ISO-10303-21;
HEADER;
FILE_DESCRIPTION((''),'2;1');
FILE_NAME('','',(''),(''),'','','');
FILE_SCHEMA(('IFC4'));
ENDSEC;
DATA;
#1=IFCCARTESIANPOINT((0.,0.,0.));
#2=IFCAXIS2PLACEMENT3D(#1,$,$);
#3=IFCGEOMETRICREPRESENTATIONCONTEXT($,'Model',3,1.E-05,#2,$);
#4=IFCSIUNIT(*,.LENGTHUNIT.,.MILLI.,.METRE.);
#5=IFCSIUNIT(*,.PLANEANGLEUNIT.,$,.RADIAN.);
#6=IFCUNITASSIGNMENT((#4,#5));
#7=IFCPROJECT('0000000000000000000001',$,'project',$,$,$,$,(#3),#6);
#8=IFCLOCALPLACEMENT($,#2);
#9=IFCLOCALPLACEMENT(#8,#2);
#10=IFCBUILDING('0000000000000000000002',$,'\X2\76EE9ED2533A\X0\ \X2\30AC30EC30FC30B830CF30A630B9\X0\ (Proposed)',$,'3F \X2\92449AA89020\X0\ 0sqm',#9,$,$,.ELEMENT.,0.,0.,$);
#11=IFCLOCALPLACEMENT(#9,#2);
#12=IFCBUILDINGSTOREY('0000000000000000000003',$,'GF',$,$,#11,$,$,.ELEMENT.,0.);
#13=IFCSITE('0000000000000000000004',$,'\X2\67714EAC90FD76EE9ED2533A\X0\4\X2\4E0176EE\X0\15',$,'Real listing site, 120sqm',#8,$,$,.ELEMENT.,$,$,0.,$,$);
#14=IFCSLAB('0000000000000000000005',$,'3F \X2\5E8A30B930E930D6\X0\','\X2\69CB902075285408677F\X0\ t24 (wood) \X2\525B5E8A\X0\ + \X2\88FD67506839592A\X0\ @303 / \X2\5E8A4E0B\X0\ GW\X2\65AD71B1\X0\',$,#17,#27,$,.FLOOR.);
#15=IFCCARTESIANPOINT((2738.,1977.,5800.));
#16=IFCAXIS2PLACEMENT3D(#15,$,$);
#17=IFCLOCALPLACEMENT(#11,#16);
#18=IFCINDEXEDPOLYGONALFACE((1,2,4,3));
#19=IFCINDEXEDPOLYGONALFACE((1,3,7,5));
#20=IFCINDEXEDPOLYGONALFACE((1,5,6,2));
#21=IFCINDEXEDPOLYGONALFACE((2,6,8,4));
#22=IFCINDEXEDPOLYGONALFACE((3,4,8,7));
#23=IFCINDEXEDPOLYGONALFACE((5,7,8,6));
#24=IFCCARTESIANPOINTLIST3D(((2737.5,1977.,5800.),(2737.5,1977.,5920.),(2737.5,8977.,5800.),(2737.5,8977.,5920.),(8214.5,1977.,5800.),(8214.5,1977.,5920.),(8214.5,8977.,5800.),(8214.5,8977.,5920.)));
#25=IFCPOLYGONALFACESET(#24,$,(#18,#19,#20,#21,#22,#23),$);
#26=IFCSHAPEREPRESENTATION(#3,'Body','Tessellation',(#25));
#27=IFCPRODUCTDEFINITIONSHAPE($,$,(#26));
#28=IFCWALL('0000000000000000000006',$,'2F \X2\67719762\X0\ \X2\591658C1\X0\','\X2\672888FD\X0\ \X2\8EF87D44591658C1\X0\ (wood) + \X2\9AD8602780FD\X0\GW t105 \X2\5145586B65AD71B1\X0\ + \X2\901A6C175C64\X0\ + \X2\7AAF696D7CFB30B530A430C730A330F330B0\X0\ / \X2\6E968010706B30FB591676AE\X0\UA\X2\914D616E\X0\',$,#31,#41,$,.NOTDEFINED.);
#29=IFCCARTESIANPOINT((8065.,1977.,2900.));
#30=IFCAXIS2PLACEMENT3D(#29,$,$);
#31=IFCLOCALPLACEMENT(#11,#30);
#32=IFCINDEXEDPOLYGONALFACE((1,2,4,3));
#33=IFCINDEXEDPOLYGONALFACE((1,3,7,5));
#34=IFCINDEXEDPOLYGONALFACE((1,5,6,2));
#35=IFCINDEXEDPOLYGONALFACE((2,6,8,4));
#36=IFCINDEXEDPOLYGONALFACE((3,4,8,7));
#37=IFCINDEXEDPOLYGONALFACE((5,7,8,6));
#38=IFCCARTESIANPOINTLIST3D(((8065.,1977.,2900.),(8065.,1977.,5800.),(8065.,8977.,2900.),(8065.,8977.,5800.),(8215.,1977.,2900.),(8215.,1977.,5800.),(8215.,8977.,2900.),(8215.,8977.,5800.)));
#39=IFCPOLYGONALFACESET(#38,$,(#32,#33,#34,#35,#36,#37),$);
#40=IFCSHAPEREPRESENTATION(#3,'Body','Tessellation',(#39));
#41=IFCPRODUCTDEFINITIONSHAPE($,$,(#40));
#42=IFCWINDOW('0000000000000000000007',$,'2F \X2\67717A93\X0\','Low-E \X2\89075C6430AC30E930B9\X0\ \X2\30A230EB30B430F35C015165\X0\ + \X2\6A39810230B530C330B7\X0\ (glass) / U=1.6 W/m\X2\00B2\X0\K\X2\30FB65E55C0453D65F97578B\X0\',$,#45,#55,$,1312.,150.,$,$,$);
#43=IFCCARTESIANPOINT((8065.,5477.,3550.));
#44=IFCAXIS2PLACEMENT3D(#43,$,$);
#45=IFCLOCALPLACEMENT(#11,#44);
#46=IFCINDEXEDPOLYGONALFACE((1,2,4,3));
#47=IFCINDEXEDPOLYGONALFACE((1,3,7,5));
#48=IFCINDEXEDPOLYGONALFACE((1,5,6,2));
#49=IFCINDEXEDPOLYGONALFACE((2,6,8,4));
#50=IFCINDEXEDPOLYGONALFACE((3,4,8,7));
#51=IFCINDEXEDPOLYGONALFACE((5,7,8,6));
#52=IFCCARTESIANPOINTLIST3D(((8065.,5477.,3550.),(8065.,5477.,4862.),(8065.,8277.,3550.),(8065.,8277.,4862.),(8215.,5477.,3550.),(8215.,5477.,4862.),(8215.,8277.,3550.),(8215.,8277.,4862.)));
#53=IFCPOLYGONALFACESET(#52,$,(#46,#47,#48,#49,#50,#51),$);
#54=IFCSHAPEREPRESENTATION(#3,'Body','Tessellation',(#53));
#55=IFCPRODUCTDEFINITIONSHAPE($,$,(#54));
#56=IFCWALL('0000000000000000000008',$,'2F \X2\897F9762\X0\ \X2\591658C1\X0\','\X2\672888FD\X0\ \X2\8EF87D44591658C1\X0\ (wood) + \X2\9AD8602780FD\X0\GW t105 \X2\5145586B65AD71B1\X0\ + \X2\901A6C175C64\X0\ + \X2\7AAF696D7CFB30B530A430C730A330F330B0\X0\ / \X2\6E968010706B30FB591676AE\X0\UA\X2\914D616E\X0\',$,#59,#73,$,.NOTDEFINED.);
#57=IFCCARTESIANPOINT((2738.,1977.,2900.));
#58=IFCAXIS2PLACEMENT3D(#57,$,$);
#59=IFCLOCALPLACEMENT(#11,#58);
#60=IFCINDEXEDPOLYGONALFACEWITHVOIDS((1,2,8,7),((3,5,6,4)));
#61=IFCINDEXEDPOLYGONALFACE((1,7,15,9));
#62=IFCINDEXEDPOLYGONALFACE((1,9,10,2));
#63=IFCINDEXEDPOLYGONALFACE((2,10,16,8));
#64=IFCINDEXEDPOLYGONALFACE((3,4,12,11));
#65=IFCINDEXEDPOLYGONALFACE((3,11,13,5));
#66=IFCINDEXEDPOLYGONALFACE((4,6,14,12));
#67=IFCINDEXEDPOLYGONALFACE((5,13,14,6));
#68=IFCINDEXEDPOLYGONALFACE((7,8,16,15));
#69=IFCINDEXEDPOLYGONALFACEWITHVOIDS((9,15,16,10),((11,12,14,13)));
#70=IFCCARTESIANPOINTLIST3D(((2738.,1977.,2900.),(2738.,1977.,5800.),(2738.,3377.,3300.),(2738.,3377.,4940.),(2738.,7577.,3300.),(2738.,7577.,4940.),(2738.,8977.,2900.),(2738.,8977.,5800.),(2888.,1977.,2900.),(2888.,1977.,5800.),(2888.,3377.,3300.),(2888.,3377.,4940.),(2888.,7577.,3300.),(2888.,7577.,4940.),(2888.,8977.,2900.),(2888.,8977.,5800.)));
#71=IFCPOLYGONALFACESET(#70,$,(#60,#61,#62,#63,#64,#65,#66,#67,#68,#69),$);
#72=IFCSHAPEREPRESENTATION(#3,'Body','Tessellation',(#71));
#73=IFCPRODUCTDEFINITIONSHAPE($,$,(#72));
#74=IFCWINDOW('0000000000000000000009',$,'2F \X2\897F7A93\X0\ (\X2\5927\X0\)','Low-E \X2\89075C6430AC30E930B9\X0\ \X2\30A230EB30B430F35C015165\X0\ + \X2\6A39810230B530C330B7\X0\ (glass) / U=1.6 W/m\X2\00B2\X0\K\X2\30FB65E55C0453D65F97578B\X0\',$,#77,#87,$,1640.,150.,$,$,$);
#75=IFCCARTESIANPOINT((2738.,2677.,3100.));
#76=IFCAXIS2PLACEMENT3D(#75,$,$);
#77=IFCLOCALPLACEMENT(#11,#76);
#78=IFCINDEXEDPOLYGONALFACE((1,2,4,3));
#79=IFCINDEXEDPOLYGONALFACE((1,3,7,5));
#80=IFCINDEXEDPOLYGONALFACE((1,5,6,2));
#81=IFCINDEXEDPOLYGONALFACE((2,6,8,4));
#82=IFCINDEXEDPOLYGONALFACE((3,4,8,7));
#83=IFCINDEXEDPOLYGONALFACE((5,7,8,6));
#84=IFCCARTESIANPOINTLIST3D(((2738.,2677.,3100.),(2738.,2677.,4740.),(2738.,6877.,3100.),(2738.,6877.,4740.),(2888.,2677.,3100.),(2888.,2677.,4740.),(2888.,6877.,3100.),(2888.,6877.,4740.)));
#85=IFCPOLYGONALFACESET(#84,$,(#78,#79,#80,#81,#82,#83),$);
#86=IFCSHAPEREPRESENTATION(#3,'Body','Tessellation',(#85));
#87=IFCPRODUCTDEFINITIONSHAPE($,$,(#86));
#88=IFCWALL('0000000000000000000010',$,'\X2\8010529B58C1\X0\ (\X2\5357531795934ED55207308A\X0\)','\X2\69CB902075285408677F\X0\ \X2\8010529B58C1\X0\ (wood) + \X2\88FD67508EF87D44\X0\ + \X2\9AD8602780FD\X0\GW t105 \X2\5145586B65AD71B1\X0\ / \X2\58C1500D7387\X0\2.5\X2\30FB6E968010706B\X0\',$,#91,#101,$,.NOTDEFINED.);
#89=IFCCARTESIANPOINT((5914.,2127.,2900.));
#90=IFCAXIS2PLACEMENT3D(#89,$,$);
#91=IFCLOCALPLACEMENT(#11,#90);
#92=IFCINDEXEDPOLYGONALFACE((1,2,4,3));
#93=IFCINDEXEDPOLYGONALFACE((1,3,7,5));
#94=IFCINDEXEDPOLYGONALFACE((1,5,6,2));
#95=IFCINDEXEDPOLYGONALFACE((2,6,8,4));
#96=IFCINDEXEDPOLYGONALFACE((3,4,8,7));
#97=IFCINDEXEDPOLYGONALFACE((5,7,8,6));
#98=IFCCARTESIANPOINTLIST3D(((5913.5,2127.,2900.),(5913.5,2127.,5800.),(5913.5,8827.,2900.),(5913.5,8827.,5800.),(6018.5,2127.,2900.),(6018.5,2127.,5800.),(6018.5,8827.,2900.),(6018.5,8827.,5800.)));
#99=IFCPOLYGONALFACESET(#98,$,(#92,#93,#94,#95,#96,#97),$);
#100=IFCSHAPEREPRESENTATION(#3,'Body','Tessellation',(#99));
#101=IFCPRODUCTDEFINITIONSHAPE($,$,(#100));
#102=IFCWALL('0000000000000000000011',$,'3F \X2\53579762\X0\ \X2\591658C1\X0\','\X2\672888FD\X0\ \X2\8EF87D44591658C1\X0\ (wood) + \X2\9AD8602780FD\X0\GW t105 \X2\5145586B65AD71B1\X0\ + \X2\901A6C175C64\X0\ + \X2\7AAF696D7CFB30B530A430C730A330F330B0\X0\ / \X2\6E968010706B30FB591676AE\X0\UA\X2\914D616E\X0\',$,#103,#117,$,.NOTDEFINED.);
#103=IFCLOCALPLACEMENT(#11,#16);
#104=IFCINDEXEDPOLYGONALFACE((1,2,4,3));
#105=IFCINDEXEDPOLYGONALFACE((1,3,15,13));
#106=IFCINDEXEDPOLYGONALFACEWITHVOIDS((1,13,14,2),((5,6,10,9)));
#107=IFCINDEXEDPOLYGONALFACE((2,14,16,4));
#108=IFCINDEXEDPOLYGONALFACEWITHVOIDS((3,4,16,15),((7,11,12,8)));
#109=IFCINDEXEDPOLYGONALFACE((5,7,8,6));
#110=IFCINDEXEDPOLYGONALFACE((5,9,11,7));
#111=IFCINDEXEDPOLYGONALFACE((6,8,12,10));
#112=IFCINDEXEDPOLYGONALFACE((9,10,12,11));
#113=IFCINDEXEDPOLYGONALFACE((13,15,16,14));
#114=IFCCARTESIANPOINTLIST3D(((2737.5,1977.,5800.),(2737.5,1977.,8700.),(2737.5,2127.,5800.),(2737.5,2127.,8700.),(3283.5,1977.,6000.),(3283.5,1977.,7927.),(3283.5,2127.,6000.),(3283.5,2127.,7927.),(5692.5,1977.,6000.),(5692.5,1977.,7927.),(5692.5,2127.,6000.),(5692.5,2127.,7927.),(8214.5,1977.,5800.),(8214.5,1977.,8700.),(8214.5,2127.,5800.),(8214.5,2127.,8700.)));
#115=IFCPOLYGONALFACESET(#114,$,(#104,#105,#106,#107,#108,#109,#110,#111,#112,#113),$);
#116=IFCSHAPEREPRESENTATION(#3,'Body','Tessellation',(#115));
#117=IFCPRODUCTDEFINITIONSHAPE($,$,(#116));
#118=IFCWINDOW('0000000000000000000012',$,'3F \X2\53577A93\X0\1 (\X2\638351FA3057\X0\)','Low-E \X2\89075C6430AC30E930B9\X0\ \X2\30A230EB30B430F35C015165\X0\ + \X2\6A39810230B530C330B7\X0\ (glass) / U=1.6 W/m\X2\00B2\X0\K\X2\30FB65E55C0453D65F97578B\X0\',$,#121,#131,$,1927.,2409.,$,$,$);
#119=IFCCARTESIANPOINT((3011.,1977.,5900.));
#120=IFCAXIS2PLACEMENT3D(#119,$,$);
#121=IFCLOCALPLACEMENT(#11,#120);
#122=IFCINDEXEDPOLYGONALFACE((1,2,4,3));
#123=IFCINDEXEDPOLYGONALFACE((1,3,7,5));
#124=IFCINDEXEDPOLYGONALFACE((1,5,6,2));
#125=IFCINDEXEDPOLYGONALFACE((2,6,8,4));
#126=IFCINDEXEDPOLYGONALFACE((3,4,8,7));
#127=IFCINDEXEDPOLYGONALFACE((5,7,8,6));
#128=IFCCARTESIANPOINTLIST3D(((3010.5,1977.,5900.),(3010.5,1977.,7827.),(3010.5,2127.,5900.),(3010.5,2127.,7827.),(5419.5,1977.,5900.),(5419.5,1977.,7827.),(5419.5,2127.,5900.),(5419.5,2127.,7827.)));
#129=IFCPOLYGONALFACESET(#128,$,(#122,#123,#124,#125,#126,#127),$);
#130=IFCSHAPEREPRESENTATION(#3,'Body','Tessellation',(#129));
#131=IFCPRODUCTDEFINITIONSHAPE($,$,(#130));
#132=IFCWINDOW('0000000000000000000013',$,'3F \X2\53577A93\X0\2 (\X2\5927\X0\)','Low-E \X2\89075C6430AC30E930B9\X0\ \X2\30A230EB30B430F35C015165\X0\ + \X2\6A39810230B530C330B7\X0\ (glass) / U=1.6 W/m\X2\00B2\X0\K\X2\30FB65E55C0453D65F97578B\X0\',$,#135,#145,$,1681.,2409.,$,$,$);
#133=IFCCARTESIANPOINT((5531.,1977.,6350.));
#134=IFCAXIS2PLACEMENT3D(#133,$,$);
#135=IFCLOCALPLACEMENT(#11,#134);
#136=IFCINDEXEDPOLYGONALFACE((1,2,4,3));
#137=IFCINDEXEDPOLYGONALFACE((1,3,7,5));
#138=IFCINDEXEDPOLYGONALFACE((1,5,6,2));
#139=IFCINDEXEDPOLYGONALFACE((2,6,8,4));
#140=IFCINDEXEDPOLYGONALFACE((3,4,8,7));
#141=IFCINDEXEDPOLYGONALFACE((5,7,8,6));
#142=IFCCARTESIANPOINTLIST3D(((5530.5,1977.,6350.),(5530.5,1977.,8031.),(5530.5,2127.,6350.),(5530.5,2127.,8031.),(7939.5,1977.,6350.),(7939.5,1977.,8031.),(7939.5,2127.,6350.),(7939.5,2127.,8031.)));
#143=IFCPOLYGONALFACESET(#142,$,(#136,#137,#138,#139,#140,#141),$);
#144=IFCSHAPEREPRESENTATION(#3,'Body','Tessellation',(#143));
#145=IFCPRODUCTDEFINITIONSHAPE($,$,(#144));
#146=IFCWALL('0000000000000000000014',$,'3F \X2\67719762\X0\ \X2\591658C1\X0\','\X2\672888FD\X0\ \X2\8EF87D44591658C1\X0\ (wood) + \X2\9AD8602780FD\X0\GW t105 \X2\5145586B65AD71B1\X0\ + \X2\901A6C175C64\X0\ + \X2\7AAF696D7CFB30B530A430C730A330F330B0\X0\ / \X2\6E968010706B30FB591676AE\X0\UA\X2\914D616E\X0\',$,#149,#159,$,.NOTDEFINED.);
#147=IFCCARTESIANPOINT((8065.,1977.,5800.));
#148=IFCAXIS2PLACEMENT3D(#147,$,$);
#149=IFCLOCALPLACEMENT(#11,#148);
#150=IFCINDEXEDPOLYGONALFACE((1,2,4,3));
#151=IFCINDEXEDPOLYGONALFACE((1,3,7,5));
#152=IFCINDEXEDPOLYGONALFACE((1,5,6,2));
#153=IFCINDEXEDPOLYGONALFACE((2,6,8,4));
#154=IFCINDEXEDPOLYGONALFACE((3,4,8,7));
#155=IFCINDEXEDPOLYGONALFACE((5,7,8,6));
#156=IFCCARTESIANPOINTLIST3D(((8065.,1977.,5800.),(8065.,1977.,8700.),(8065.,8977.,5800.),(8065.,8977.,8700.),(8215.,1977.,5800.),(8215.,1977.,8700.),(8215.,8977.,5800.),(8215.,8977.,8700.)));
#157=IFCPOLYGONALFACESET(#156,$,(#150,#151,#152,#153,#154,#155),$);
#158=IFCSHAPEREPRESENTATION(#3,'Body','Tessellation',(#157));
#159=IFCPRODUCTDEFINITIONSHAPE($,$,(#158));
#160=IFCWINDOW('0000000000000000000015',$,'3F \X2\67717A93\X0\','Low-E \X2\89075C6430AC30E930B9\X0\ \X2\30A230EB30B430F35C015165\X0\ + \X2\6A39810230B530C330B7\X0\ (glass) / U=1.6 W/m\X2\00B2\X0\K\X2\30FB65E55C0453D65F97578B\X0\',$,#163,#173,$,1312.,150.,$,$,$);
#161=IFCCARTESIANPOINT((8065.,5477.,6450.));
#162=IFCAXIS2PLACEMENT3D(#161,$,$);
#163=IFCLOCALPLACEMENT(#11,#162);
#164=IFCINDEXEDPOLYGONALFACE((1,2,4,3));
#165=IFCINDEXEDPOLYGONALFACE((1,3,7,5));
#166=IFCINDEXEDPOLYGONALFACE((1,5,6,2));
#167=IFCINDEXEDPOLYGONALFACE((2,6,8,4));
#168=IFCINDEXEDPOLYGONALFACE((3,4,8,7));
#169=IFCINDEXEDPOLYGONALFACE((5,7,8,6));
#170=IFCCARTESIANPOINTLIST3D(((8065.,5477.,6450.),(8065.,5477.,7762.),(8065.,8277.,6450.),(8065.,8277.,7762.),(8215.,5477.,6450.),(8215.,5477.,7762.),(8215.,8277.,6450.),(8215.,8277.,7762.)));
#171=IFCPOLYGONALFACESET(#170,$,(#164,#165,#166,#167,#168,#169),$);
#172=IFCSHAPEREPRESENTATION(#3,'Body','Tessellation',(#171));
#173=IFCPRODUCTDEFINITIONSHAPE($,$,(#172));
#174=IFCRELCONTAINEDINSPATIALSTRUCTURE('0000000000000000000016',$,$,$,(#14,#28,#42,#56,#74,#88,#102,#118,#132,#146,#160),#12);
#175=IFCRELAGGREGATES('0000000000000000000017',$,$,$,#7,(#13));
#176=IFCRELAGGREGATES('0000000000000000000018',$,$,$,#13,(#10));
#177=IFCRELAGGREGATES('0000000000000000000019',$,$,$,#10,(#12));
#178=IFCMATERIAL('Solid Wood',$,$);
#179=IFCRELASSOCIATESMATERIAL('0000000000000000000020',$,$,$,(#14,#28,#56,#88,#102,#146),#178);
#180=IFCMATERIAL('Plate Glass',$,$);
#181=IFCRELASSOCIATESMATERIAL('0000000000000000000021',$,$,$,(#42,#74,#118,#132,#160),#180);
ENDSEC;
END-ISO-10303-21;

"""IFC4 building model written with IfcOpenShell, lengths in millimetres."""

from ifc_helpers import new_model, si_unit, frame, frame_2d, origin, place, context, project, spatial, rectangle, extrude, material, element, fill, save


model = new_model("IFC4")

# Units and contexts
model_context = context("Model", 3, precision=1e-05, world=origin())
ifc_project = project(units=[si_unit("LENGTHUNIT", "METRE", prefix="MILLI"), si_unit("PLANEANGLEUNIT", "RADIAN")], contexts=[model_context])

# Site, building, storey
site_placement = place(None, origin())
site = spatial("IfcSite", under=ifc_project, at=site_placement, Name="東京都目黒区4丁目15", ObjectType="Real listing site, 120sqm", CompositionType="ELEMENT", RefElevation=0.0)
building_placement = place(site_placement, origin())
building = spatial("IfcBuilding", under=site, at=building_placement, Name="目黒区 ガレージハウス (Proposed)", ObjectType="3F 鉄骨造 0sqm", CompositionType="ELEMENT", ElevationOfRefHeight=0.0, ElevationOfTerrain=0.0)
storey_placement = place(building_placement, origin())
storey = spatial("IfcBuildingStorey", under=building, at=storey_placement, Name="GF", CompositionType="ELEMENT", Elevation=0.0)

# Slab
ifc_material_1 = material(Name="Solid Wood")
slab_placement = place(storey_placement, frame((2738.0, 1977.0, 5800.0)))
element("IfcSlab", 1, at=slab_placement, inside=storey, material=ifc_material_1, Name="3F 床スラブ", Description="構造用合板 t24 (wood) 剛床 + 製材根太 @303 / 床下 GW断熱", PredefinedType="FLOOR", context=model_context, shape_type="SweptSolid", body=[
    extrude(rectangle(XDim=5477.0, YDim=7000.0, at=frame_2d((2738.0, 3500.0))), frame((2738.0, 1977.0, 5800.0)), (0.0, 0.0, 1.0), 120.0),
])

# Walls, openings, windows
wall_1_placement = place(storey_placement, frame((8065.0, 1977.0, 2900.0)))
wall_1 = element("IfcWall", 2, at=wall_1_placement, inside=storey, material=ifc_material_1, Name="2F 東面 外壁", Description="木製 軸組外壁 (wood) + 高性能GW t105 充填断熱 + 通気層 + 窯業系サイディング / 準耐火・外皮UA配慮", PredefinedType="NOTDEFINED", context=model_context, shape_type="SweptSolid", body=[
    extrude(rectangle(XDim=150.0, YDim=7000.0, at=frame_2d((75.0, 3500.0))), frame((8065.0, 1977.0, 2900.0)), (0.0, 0.0, 1.0), 2900.0),
])
opening_1_placement = place(storey_placement, frame((8065.0, 5477.0, 3550.0)))
opening_1 = element("IfcOpeningElement", 3, at=opening_1_placement, cuts=wall_1, PredefinedType="NOTDEFINED", context=model_context, shape_type="SweptSolid", body=[
    extrude(rectangle(XDim=150.0, YDim=2800.0, at=frame_2d((75.0, 1400.0))), frame((8065.0, 5477.0, 3550.0)), (0.0, 0.0, 1.0), 1312.0),
])
ifc_material_2 = material(Name="Plate Glass")
window_1_placement = place(storey_placement, frame((8065.0, 5477.0, 3550.0)))
window_1 = element("IfcWindow", 4, at=window_1_placement, inside=storey, material=ifc_material_2, Name="2F 東窓", Description="Low-E 複層ガラス アルゴン封入 + 樹脂サッシ (glass) / U=1.6 W/m²K・日射取得型", OverallHeight=1312.0, OverallWidth=150.0, context=model_context, shape_type="SweptSolid", body=[
    extrude(rectangle(XDim=150.0, YDim=2800.0, at=frame_2d((75.0, 1400.0))), frame((8065.0, 5477.0, 3550.0)), (0.0, 0.0, 1.0), 1312.0),
])
fill(opening_1, window_1)
wall_2_placement = place(storey_placement, frame((2738.0, 1977.0, 2900.0)))
wall_2 = element("IfcWall", 5, at=wall_2_placement, inside=storey, material=ifc_material_1, Name="2F 西面 外壁", Description="木製 軸組外壁 (wood) + 高性能GW t105 充填断熱 + 通気層 + 窯業系サイディング / 準耐火・外皮UA配慮", PredefinedType="NOTDEFINED", context=model_context, shape_type="SweptSolid", body=[
    extrude(rectangle(XDim=150.0, YDim=7000.0, at=frame_2d((75.0, 3500.0))), frame((2738.0, 1977.0, 2900.0)), (0.0, 0.0, 1.0), 2900.0),
])
opening_2_placement = place(storey_placement, frame((2738.0, 2677.0, 3100.0)))
opening_2 = element("IfcOpeningElement", 6, at=opening_2_placement, cuts=wall_2, PredefinedType="NOTDEFINED", context=model_context, shape_type="SweptSolid", body=[
    extrude(rectangle(XDim=150.0, YDim=4200.0, at=frame_2d((75.0, 2100.0))), frame((2738.0, 2677.0, 3100.0)), (0.0, 0.0, 1.0), 1640.0),
])
window_2_placement = place(storey_placement, frame((2738.0, 2677.0, 3100.0)))
window_2 = element("IfcWindow", 7, at=window_2_placement, inside=storey, material=ifc_material_2, Name="2F 西窓 (大)", Description="Low-E 複層ガラス アルゴン封入 + 樹脂サッシ (glass) / U=1.6 W/m²K・日射取得型", OverallHeight=1640.0, OverallWidth=150.0, context=model_context, shape_type="SweptSolid", body=[
    extrude(rectangle(XDim=150.0, YDim=4200.0, at=frame_2d((75.0, 2100.0))), frame((2738.0, 2677.0, 3100.0)), (0.0, 0.0, 1.0), 1640.0),
])
fill(opening_2, window_2)

# Wall
wall_3_placement = place(storey_placement, frame((5914.0, 2127.0, 2900.0)))
element("IfcWall", 8, at=wall_3_placement, inside=storey, material=ifc_material_1, Name="耐力壁 (南北間仕切り)", Description="構造用合板 耐力壁 (wood) + 製材軸組 + 高性能GW t105 充填断熱 / 壁倍率2.5・準耐火", PredefinedType="NOTDEFINED", context=model_context, shape_type="SweptSolid", body=[
    extrude(rectangle(XDim=105.0, YDim=6700.0, at=frame_2d((52.0, 3350.0))), frame((5914.0, 2127.0, 2900.0)), (0.0, 0.0, 1.0), 2900.0),
])

# Wall, openings, windows
wall_4_placement = place(storey_placement, frame((2738.0, 1977.0, 5800.0)))
wall_4 = element("IfcWall", 9, at=wall_4_placement, inside=storey, material=ifc_material_1, Name="3F 南面 外壁", Description="木製 軸組外壁 (wood) + 高性能GW t105 充填断熱 + 通気層 + 窯業系サイディング / 準耐火・外皮UA配慮", PredefinedType="NOTDEFINED", context=model_context, shape_type="SweptSolid", body=[
    extrude(rectangle(XDim=5477.0, YDim=150.0, at=frame_2d((2738.0, 75.0))), frame((2738.0, 1977.0, 5800.0)), (0.0, 0.0, 1.0), 2900.0),
])
opening_3_placement = place(storey_placement, frame((3011.0, 1977.0, 5900.0)))
opening_3 = element("IfcOpeningElement", 10, at=opening_3_placement, cuts=wall_4, PredefinedType="NOTDEFINED", context=model_context, shape_type="SweptSolid", body=[
    extrude(rectangle(XDim=2409.0, YDim=150.0, at=frame_2d((1204.0, 75.0))), frame((3011.0, 1977.0, 5900.0)), (0.0, 0.0, 1.0), 1927.0),
])
opening_4_placement = place(storey_placement, frame((5531.0, 1977.0, 6350.0)))
opening_4 = element("IfcOpeningElement", 11, at=opening_4_placement, cuts=wall_4, PredefinedType="NOTDEFINED", context=model_context, shape_type="SweptSolid", body=[
    extrude(rectangle(XDim=2409.0, YDim=150.0, at=frame_2d((1204.0, 75.0))), frame((5531.0, 1977.0, 6350.0)), (0.0, 0.0, 1.0), 1681.0),
])
window_3_placement = place(storey_placement, frame((3011.0, 1977.0, 5900.0)))
window_3 = element("IfcWindow", 12, at=window_3_placement, inside=storey, material=ifc_material_2, Name="3F 南窓1 (掃出し)", Description="Low-E 複層ガラス アルゴン封入 + 樹脂サッシ (glass) / U=1.6 W/m²K・日射取得型", OverallHeight=1927.0, OverallWidth=2409.0, context=model_context, shape_type="SweptSolid", body=[
    extrude(rectangle(XDim=2409.0, YDim=150.0, at=frame_2d((1204.0, 75.0))), frame((3011.0, 1977.0, 5900.0)), (0.0, 0.0, 1.0), 1927.0),
])
fill(opening_3, window_3)
window_4_placement = place(storey_placement, frame((5531.0, 1977.0, 6350.0)))
window_4 = element("IfcWindow", 13, at=window_4_placement, inside=storey, material=ifc_material_2, Name="3F 南窓2 (大)", Description="Low-E 複層ガラス アルゴン封入 + 樹脂サッシ (glass) / U=1.6 W/m²K・日射取得型", OverallHeight=1681.0, OverallWidth=2409.0, context=model_context, shape_type="SweptSolid", body=[
    extrude(rectangle(XDim=2409.0, YDim=150.0, at=frame_2d((1204.0, 75.0))), frame((5531.0, 1977.0, 6350.0)), (0.0, 0.0, 1.0), 1681.0),
])
fill(opening_4, window_4)

# Wall, opening, window
wall_5_placement = place(storey_placement, frame((8065.0, 1977.0, 5800.0)))
wall_5 = element("IfcWall", 14, at=wall_5_placement, inside=storey, material=ifc_material_1, Name="3F 東面 外壁", Description="木製 軸組外壁 (wood) + 高性能GW t105 充填断熱 + 通気層 + 窯業系サイディング / 準耐火・外皮UA配慮", PredefinedType="NOTDEFINED", context=model_context, shape_type="SweptSolid", body=[
    extrude(rectangle(XDim=150.0, YDim=7000.0, at=frame_2d((75.0, 3500.0))), frame((8065.0, 1977.0, 5800.0)), (0.0, 0.0, 1.0), 2900.0),
])
opening_5_placement = place(storey_placement, frame((8065.0, 5477.0, 6450.0)))
opening_5 = element("IfcOpeningElement", 15, at=opening_5_placement, cuts=wall_5, PredefinedType="NOTDEFINED", context=model_context, shape_type="SweptSolid", body=[
    extrude(rectangle(XDim=150.0, YDim=2800.0, at=frame_2d((75.0, 1400.0))), frame((8065.0, 5477.0, 6450.0)), (0.0, 0.0, 1.0), 1312.0),
])
window_5_placement = place(storey_placement, frame((8065.0, 5477.0, 6450.0)))
window_5 = element("IfcWindow", 16, at=window_5_placement, inside=storey, material=ifc_material_2, Name="3F 東窓", Description="Low-E 複層ガラス アルゴン封入 + 樹脂サッシ (glass) / U=1.6 W/m²K・日射取得型", OverallHeight=1312.0, OverallWidth=150.0, context=model_context, shape_type="SweptSolid", body=[
    extrude(rectangle(XDim=150.0, YDim=2800.0, at=frame_2d((75.0, 1400.0))), frame((8065.0, 5477.0, 6450.0)), (0.0, 0.0, 1.0), 1312.0),
])
fill(opening_5, window_5)

save(model, "model.ifc")
